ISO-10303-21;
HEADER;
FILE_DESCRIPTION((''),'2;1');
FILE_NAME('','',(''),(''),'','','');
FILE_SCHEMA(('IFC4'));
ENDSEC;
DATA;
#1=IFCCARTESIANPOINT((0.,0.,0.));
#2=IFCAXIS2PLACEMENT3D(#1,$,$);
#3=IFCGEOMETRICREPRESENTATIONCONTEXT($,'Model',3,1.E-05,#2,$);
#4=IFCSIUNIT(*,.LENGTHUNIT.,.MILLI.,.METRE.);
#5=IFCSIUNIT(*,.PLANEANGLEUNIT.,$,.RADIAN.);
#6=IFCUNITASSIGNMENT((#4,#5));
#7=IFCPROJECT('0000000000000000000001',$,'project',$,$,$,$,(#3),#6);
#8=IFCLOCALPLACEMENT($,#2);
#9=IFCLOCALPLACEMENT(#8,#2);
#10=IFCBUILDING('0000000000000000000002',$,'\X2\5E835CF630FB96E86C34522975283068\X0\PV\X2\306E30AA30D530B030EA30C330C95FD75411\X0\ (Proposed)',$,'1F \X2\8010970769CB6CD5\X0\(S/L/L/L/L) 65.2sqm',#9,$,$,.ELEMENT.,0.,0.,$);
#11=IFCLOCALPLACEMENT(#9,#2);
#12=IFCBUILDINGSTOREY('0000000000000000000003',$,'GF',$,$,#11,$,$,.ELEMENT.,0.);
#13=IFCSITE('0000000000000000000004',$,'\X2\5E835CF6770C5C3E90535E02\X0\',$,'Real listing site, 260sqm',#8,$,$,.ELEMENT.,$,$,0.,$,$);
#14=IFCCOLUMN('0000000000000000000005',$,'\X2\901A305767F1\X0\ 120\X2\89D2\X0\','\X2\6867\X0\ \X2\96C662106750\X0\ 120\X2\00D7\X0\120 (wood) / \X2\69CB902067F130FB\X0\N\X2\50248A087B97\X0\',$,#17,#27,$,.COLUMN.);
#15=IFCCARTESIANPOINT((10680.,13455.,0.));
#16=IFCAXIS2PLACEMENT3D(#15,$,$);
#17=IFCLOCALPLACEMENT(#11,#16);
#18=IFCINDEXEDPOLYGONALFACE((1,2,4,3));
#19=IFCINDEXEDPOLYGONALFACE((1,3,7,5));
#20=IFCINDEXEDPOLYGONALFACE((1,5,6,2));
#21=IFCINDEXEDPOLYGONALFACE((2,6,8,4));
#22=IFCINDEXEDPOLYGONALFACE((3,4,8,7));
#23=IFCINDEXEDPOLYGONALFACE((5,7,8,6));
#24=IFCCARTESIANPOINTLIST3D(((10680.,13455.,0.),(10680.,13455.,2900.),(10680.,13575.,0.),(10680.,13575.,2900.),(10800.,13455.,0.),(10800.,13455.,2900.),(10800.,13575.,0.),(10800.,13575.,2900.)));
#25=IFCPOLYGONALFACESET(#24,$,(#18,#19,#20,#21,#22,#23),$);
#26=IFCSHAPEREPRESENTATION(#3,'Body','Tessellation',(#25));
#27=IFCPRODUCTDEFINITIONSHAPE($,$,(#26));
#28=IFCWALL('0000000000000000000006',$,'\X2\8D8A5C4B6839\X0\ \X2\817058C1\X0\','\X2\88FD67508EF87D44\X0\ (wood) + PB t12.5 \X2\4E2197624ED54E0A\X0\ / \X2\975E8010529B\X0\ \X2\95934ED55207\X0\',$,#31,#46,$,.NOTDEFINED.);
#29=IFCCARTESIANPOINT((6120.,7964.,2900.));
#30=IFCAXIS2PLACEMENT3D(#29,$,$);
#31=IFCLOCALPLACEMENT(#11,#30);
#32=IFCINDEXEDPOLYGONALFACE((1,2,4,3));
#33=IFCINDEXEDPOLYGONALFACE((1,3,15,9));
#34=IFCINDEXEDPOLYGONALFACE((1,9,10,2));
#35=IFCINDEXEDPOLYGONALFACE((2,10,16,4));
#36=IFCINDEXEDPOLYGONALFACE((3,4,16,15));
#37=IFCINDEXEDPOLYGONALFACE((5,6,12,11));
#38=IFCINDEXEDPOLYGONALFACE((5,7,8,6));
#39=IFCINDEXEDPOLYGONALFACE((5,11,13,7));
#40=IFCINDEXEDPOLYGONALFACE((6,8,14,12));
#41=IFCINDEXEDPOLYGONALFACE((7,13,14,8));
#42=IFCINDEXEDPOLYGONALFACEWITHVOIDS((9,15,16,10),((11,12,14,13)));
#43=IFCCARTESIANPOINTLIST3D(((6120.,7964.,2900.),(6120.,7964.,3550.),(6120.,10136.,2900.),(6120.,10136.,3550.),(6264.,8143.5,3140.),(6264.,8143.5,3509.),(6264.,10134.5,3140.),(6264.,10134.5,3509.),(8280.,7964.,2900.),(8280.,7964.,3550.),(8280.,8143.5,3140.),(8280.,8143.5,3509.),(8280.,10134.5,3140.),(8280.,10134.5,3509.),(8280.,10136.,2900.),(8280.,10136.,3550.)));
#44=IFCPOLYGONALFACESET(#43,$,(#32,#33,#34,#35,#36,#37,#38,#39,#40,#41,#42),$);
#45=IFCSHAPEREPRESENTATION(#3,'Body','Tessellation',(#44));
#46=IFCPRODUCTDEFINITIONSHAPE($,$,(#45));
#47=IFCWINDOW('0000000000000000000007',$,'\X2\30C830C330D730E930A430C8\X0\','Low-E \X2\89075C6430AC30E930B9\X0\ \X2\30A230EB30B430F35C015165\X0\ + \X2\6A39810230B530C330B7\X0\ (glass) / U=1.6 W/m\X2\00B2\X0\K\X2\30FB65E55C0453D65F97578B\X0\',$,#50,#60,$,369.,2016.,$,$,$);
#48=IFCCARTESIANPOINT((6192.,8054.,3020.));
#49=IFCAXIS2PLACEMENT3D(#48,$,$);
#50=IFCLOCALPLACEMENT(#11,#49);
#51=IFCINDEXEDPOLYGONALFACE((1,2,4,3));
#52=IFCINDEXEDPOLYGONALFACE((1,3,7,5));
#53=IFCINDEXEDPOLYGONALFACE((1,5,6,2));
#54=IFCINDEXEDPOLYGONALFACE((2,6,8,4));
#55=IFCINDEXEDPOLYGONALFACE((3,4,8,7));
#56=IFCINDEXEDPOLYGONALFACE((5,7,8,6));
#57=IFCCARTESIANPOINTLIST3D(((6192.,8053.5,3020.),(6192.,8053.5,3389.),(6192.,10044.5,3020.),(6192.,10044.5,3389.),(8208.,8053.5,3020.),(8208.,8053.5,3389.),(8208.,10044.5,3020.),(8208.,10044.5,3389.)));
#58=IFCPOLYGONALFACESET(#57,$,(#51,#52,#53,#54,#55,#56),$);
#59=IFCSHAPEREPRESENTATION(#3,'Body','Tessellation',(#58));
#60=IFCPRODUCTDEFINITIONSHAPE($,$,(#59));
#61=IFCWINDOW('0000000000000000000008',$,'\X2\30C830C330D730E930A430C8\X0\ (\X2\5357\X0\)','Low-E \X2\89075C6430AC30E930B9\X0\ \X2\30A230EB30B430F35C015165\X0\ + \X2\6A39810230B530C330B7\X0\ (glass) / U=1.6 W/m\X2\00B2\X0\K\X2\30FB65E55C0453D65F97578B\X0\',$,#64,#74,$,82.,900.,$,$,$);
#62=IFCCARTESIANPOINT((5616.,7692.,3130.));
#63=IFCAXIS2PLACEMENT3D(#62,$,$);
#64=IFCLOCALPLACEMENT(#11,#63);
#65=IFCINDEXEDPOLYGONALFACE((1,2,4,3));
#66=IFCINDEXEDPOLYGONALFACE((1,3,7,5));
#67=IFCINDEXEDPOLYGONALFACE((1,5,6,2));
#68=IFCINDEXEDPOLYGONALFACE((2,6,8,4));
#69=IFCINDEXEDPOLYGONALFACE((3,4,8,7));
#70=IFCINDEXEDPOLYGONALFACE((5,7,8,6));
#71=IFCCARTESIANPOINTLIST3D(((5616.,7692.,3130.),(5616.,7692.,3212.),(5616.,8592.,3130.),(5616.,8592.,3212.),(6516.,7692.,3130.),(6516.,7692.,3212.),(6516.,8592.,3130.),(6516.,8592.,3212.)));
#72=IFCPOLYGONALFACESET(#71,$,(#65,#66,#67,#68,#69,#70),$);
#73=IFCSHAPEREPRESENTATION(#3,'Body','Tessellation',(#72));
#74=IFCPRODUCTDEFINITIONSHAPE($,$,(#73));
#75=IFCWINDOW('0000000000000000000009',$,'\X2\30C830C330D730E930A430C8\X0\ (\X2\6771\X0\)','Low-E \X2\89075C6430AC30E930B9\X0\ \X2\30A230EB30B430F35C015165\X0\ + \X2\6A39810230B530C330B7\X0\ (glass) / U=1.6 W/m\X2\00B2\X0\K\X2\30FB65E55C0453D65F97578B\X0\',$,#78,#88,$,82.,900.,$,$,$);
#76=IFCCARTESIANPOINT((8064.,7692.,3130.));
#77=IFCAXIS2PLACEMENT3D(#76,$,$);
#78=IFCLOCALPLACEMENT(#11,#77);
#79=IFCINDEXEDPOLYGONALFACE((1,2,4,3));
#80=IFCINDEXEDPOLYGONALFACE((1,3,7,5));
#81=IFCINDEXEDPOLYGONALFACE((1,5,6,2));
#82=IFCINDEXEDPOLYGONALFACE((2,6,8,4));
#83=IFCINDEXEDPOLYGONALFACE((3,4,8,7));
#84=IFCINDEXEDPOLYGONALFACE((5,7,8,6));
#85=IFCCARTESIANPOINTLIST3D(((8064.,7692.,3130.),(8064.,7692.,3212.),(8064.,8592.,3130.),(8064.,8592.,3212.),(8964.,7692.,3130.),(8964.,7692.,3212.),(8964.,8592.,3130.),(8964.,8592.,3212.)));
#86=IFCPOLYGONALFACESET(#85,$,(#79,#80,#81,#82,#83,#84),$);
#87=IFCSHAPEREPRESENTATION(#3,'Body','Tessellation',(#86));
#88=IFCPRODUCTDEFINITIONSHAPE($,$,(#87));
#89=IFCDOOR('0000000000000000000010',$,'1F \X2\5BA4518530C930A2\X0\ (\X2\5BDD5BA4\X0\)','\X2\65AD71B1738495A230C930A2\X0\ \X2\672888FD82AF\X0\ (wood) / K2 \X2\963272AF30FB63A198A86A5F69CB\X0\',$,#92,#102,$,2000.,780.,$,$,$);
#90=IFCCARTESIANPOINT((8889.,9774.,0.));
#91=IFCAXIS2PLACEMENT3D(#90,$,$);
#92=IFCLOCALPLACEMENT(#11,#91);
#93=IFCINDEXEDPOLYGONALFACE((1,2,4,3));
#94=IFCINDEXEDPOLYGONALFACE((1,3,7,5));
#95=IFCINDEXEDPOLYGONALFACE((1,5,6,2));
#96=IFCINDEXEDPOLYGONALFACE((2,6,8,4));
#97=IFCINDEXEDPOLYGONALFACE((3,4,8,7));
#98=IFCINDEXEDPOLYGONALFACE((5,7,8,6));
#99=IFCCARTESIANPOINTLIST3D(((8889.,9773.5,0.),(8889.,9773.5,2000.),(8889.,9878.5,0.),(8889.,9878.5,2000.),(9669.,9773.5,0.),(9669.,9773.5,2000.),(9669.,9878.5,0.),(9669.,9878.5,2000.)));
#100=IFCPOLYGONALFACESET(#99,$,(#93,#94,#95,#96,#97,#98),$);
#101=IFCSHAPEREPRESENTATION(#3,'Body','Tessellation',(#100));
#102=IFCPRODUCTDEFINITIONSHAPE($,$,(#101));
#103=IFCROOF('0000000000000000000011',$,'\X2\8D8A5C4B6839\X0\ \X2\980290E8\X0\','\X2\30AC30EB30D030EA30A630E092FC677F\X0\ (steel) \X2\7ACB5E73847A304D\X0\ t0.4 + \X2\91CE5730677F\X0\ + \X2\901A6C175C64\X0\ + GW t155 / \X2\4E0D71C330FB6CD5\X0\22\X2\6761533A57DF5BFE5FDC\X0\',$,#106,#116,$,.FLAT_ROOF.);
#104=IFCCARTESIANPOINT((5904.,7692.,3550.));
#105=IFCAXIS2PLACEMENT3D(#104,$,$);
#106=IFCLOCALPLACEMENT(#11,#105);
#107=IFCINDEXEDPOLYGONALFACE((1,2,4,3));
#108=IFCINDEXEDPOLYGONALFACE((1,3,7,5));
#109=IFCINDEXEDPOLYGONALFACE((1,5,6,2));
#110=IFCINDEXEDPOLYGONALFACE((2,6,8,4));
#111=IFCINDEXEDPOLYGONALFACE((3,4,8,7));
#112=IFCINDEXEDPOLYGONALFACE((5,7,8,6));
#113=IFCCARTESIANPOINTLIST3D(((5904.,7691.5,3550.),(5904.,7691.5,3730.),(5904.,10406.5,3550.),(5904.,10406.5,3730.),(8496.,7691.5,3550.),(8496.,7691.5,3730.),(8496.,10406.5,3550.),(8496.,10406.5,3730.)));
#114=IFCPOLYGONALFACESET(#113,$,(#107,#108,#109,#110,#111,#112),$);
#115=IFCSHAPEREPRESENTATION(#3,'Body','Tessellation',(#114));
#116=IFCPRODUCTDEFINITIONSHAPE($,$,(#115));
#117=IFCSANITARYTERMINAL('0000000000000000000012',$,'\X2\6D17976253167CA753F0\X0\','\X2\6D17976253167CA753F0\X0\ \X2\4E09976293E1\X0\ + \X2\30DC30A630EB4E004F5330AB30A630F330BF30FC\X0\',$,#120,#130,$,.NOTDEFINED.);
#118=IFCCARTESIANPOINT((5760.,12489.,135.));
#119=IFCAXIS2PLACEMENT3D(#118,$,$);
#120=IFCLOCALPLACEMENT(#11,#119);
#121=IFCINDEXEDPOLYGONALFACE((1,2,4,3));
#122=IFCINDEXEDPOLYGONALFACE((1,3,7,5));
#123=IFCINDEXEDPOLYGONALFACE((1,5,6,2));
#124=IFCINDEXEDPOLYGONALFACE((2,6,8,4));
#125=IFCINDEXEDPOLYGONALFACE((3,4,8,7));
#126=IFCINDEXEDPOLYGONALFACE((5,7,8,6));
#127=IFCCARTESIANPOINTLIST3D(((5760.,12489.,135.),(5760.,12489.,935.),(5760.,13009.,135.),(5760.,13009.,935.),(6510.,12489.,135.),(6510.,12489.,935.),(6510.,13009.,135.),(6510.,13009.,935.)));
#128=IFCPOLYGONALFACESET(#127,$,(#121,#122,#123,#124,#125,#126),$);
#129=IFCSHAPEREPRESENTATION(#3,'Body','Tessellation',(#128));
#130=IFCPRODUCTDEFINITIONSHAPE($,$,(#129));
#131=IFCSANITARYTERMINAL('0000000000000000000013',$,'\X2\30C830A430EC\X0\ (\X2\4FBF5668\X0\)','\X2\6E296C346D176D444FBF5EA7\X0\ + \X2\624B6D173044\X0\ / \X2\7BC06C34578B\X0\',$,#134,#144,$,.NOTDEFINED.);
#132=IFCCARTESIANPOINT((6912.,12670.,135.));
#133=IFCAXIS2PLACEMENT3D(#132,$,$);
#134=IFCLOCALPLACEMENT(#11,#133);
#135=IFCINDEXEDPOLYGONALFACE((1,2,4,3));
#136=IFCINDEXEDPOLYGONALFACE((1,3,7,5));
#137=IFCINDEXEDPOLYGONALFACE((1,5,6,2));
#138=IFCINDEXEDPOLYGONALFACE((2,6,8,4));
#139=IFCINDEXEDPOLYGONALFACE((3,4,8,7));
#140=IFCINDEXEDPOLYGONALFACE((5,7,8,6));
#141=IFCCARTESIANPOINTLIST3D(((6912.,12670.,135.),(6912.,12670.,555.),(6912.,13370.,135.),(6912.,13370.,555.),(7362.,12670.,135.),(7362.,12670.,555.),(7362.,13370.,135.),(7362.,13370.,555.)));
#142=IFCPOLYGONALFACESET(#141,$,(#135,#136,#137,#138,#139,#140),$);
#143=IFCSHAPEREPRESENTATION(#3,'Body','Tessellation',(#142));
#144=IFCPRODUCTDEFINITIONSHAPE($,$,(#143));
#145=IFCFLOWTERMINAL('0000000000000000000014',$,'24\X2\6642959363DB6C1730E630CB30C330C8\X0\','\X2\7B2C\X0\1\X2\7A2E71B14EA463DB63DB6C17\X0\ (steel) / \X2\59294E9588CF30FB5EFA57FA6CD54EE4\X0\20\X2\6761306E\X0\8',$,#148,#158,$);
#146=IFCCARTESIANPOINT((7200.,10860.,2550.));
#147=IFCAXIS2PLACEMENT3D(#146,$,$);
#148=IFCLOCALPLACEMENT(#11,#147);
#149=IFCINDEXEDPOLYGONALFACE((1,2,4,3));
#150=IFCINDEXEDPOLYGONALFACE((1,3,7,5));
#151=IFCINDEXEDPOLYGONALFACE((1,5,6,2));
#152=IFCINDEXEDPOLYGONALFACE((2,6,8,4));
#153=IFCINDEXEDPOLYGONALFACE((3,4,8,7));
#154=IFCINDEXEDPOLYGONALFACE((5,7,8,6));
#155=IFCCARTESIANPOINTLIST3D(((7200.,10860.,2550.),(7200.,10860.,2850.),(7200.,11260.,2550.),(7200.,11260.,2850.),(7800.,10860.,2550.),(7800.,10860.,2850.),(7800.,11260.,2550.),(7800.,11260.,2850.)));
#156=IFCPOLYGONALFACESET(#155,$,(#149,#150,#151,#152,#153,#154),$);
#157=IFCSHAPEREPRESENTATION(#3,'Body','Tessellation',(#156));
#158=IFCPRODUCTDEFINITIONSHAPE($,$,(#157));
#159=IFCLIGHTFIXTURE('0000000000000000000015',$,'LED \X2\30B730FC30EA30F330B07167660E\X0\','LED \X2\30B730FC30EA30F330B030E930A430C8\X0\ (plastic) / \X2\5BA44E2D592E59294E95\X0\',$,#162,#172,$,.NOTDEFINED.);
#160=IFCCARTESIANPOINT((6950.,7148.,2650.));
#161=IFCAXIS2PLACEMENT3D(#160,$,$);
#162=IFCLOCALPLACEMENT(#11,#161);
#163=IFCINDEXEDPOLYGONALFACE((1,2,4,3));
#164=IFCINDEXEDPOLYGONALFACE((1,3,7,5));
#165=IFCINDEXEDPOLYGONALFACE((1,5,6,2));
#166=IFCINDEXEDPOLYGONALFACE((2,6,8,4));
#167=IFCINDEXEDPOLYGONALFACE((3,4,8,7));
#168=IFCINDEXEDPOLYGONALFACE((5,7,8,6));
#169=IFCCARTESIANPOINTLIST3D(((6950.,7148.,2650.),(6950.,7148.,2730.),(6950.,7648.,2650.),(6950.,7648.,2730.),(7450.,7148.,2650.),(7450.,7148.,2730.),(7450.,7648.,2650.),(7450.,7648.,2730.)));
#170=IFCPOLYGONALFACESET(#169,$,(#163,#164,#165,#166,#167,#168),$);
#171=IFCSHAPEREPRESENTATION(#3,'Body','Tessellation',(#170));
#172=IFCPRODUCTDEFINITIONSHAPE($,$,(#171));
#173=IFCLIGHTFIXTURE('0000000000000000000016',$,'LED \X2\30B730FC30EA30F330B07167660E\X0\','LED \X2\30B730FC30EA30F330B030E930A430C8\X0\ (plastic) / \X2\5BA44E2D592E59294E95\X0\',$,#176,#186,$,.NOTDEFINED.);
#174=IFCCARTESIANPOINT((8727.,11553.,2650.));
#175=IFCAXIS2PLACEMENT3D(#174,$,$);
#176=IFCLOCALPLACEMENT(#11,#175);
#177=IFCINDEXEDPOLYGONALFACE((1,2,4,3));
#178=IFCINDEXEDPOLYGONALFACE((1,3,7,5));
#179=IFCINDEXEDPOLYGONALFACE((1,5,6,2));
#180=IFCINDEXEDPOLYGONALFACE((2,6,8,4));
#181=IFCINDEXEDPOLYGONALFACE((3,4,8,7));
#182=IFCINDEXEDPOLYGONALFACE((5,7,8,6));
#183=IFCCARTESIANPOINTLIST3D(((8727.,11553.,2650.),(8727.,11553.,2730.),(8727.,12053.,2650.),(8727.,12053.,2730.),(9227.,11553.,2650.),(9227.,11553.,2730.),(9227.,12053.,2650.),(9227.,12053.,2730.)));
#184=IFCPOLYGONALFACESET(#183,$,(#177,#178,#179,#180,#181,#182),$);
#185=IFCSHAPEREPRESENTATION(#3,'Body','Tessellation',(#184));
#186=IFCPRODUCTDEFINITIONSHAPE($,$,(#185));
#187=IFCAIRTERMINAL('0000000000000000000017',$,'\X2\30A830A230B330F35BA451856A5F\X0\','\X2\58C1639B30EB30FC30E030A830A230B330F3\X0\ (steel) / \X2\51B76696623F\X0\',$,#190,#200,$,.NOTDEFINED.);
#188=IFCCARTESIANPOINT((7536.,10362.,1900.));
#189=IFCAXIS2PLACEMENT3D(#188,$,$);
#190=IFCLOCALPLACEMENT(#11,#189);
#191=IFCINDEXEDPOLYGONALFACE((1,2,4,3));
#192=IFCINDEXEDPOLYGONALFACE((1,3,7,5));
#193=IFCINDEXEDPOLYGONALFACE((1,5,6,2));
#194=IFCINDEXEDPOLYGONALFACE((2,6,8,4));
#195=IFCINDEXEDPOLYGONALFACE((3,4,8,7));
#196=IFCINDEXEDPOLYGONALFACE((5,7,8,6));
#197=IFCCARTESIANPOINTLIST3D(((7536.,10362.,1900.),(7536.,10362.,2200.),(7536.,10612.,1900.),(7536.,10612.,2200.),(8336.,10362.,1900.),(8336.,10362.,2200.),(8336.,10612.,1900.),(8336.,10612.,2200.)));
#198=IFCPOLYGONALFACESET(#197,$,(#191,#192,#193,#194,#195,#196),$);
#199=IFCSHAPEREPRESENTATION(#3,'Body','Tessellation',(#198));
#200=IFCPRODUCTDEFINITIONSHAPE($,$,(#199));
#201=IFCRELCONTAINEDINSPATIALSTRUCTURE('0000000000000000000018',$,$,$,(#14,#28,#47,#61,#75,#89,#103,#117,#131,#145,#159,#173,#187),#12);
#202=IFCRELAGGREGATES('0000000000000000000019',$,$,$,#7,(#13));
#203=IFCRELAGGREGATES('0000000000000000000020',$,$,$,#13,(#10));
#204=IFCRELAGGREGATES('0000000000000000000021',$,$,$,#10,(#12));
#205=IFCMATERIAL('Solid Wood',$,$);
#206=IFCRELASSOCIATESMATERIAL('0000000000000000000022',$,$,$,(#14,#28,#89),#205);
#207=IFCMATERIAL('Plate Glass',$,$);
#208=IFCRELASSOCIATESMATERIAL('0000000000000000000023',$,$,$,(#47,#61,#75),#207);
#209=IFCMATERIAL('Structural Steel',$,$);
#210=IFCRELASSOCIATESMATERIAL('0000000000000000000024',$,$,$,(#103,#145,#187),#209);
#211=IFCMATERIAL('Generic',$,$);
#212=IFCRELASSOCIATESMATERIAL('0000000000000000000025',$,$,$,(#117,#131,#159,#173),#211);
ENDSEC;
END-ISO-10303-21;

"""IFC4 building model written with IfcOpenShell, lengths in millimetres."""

from ifc_helpers import new_model, si_unit, frame, frame_2d, origin, place, context, project, spatial, rectangle, extrude, material, element, fill, save


model = new_model("IFC4")

# Units and contexts
model_context = context("Model", 3, precision=1e-05, world=origin())
ifc_project = project(units=[si_unit("LENGTHUNIT", "METRE", prefix="MILLI"), si_unit("PLANEANGLEUNIT", "RADIAN")], contexts=[model_context])

# Site, building, storey
site_placement = place(None, origin())
site = spatial("IfcSite", under=ifc_project, at=site_placement, Name="広島県尾道市", ObjectType="Real listing site, 260sqm", CompositionType="ELEMENT", RefElevation=0.0)
building_placement = place(site_placement, origin())
building = spatial("IfcBuilding", under=site, at=building_placement, Name="広島・雨水利用とPVのオフグリッド志向 (Proposed)", ObjectType="1F 耐震構法(S/L/L/L/L) 65.2sqm", CompositionType="ELEMENT", ElevationOfRefHeight=0.0, ElevationOfTerrain=0.0)
storey_placement = place(building_placement, origin())
storey = spatial("IfcBuildingStorey", under=building, at=storey_placement, Name="GF", CompositionType="ELEMENT", Elevation=0.0)

# Column
ifc_material_1 = material(Name="Solid Wood")
column_1_placement = place(storey_placement, frame((10680.0, 13455.0, 0.0)))
element("IfcColumn", 1, at=column_1_placement, inside=storey, material=ifc_material_1, Name="通し柱 120角", Description="桧 集成材 120×120 (wood) / 構造柱・N値計算", PredefinedType="COLUMN", context=model_context, shape_type="SweptSolid", body=[
    extrude(rectangle(XDim=120.0, YDim=120.0, at=frame_2d((60.0, 60.0))), frame((10680.0, 13455.0, 0.0)), (0.0, 0.0, 1.0), 2900.0),
])

# Wall, openings, windows
wall_1_placement = place(storey_placement, frame((6120.0, 7964.0, 2900.0)))
wall_1 = element("IfcWall", 2, at=wall_1_placement, inside=storey, material=ifc_material_1, Name="越屋根 腰壁", Description="製材軸組 (wood) + PB t12.5 両面仕上 / 非耐力 間仕切", PredefinedType="NOTDEFINED", context=model_context, shape_type="SweptSolid", body=[
    extrude(rectangle(XDim=2160.0, YDim=2172.0, at=frame_2d((1080.0, 1086.0))), frame((6120.0, 7964.0, 2900.0)), (0.0, 0.0, 1.0), 650.0),
])
opening_1_placement = place(storey_placement, frame((6192.0, 8054.0, 3020.0)))
opening_1 = element("IfcOpeningElement", 3, at=opening_1_placement, cuts=wall_1, PredefinedType="NOTDEFINED", context=model_context, shape_type="SweptSolid", body=[
    extrude(rectangle(XDim=2016.0, YDim=1991.0, at=frame_2d((1008.0, 995.0))), frame((6192.0, 8054.0, 3020.0)), (0.0, 0.0, 1.0), 369.0),
])
opening_2_placement = place(storey_placement, frame((5616.0, 7692.0, 3130.0)))
opening_2 = element("IfcOpeningElement", 4, at=opening_2_placement, cuts=wall_1, PredefinedType="NOTDEFINED", context=model_context, shape_type="SweptSolid", body=[
    extrude(rectangle(XDim=900.0, YDim=900.0, at=frame_2d((450.0, 450.0))), frame((5616.0, 7692.0, 3130.0)), (0.0, 0.0, 1.0), 82.0),
])
opening_3_placement = place(storey_placement, frame((8064.0, 7692.0, 3130.0)))
opening_3 = element("IfcOpeningElement", 5, at=opening_3_placement, cuts=wall_1, PredefinedType="NOTDEFINED", context=model_context, shape_type="SweptSolid", body=[
    extrude(rectangle(XDim=900.0, YDim=900.0, at=frame_2d((450.0, 450.0))), frame((8064.0, 7692.0, 3130.0)), (0.0, 0.0, 1.0), 82.0),
])
ifc_material_2 = material(Name="Plate Glass")
window_1_placement = place(storey_placement, frame((6192.0, 8054.0, 3020.0)))
window_1 = element("IfcWindow", 6, at=window_1_placement, inside=storey, material=ifc_material_2, Name="トップライト", Description="Low-E 複層ガラス アルゴン封入 + 樹脂サッシ (glass) / U=1.6 W/m²K・日射取得型", OverallHeight=369.0, OverallWidth=2016.0, context=model_context, shape_type="SweptSolid", body=[
    extrude(rectangle(XDim=2016.0, YDim=1991.0, at=frame_2d((1008.0, 995.0))), frame((6192.0, 8054.0, 3020.0)), (0.0, 0.0, 1.0), 369.0),
])
fill(opening_1, window_1)
window_2_placement = place(storey_placement, frame((5616.0, 7692.0, 3130.0)))
window_2 = element("IfcWindow", 7, at=window_2_placement, inside=storey, material=ifc_material_2, Name="トップライト (南)", Description="Low-E 複層ガラス アルゴン封入 + 樹脂サッシ (glass) / U=1.6 W/m²K・日射取得型", OverallHeight=82.0, OverallWidth=900.0, context=model_context, shape_type="SweptSolid", body=[
    extrude(rectangle(XDim=900.0, YDim=900.0, at=frame_2d((450.0, 450.0))), frame((5616.0, 7692.0, 3130.0)), (0.0, 0.0, 1.0), 82.0),
])
fill(opening_2, window_2)
window_3_placement = place(storey_placement, frame((8064.0, 7692.0, 3130.0)))
window_3 = element("IfcWindow", 8, at=window_3_placement, inside=storey, material=ifc_material_2, Name="トップライト (東)", Description="Low-E 複層ガラス アルゴン封入 + 樹脂サッシ (glass) / U=1.6 W/m²K・日射取得型", OverallHeight=82.0, OverallWidth=900.0, context=model_context, shape_type="SweptSolid", body=[
    extrude(rectangle(XDim=900.0, YDim=900.0, at=frame_2d((450.0, 450.0))), frame((8064.0, 7692.0, 3130.0)), (0.0, 0.0, 1.0), 82.0),
])
fill(opening_3, window_3)

# Door
door_placement = place(storey_placement, frame((8889.0, 9774.0, 0.0)))
element("IfcDoor", 9, at=door_placement, inside=storey, material=ifc_material_1, Name="1F 室内ドア (寝室)", Description="断熱玄関ドア 木製芯 (wood) / K2 防犯・採風機構", OverallHeight=2000.0, OverallWidth=780.0, context=model_context, shape_type="SweptSolid", body=[
    extrude(rectangle(XDim=780.0, YDim=105.0, at=frame_2d((390.0, 52.0))), frame((8889.0, 9774.0, 0.0)), (0.0, 0.0, 1.0), 2000.0),
])

# Roof
ifc_material_3 = material(Name="Structural Steel")
roof_placement = place(storey_placement, frame((5904.0, 7692.0, 3550.0)))
element("IfcRoof", 10, at=roof_placement, inside=storey, material=ifc_material_3, Name="越屋根 頂部", Description="ガルバリウム鋼板 (steel) 立平葺き t0.4 + 野地板 + 通気層 + GW t155 / 不燃・法22条区域対応", PredefinedType="FLAT_ROOF", context=model_context, shape_type="SweptSolid", body=[
    extrude(rectangle(XDim=2592.0, YDim=2715.0, at=frame_2d((1296.0, 1357.0))), frame((5904.0, 7692.0, 3550.0)), (0.0, 0.0, 1.0), 180.0),
])

# Sanitary terminals
ifc_material_4 = material(Name="Generic")
sanitary_terminal_1_placement = place(storey_placement, frame((5760.0, 12489.0, 135.0)))
element("IfcSanitaryTerminal", 11, at=sanitary_terminal_1_placement, inside=storey, material=ifc_material_4, Name="洗面化粧台", Description="洗面化粧台 三面鏡 + ボウル一体カウンター", PredefinedType="NOTDEFINED", context=model_context, shape_type="SweptSolid", body=[
    extrude(rectangle(XDim=750.0, YDim=520.0, at=frame_2d((375.0, 260.0))), frame((5760.0, 12489.0, 135.0)), (0.0, 0.0, 1.0), 800.0),
])
sanitary_terminal_2_placement = place(storey_placement, frame((6912.0, 12670.0, 135.0)))
element("IfcSanitaryTerminal", 12, at=sanitary_terminal_2_placement, inside=storey, material=ifc_material_4, Name="トイレ (便器)", Description="温水洗浄便座 + 手洗い / 節水型", PredefinedType="NOTDEFINED", context=model_context, shape_type="SweptSolid", body=[
    extrude(rectangle(XDim=450.0, YDim=700.0, at=frame_2d((225.0, 350.0))), frame((6912.0, 12670.0, 135.0)), (0.0, 0.0, 1.0), 420.0),
])

# Flow terminal
flow_terminal_placement = place(storey_placement, frame((7200.0, 10860.0, 2550.0)))
element("IfcFlowTerminal", 13, at=flow_terminal_placement, inside=storey, material=ifc_material_3, Name="24時間換気ユニット", Description="第1種熱交換換気 (steel) / 天井裏・建基法令20条の8", context=model_context, shape_type="SweptSolid", body=[
    extrude(rectangle(XDim=600.0, YDim=400.0, at=frame_2d((300.0, 200.0))), frame((7200.0, 10860.0, 2550.0)), (0.0, 0.0, 1.0), 300.0),
])

# Light fixtures
light_fixture_1_placement = place(storey_placement, frame((6950.0, 7148.0, 2650.0)))
element("IfcLightFixture", 14, at=light_fixture_1_placement, inside=storey, material=ifc_material_4, Name="LED シーリング照明", Description="LED シーリングライト (plastic) / 室中央天井", PredefinedType="NOTDEFINED", context=model_context, shape_type="SweptSolid", body=[
    extrude(rectangle(XDim=500.0, YDim=500.0, at=frame_2d((250.0, 250.0))), frame((6950.0, 7148.0, 2650.0)), (0.0, 0.0, 1.0), 80.0),
])
light_fixture_2_placement = place(storey_placement, frame((8727.0, 11553.0, 2650.0)))
element("IfcLightFixture", 15, at=light_fixture_2_placement, inside=storey, material=ifc_material_4, Name="LED シーリング照明", Description="LED シーリングライト (plastic) / 室中央天井", PredefinedType="NOTDEFINED", context=model_context, shape_type="SweptSolid", body=[
    extrude(rectangle(XDim=500.0, YDim=500.0, at=frame_2d((250.0, 250.0))), frame((8727.0, 11553.0, 2650.0)), (0.0, 0.0, 1.0), 80.0),
])

# Air terminal
air_terminal_placement = place(storey_placement, frame((7536.0, 10362.0, 1900.0)))
element("IfcAirTerminal", 16, at=air_terminal_placement, inside=storey, material=ifc_material_3, Name="エアコン室内機", Description="壁掛ルームエアコン (steel) / 冷暖房", PredefinedType="NOTDEFINED", context=model_context, shape_type="SweptSolid", body=[
    extrude(rectangle(XDim=800.0, YDim=250.0, at=frame_2d((400.0, 125.0))), frame((7536.0, 10362.0, 1900.0)), (0.0, 0.0, 1.0), 300.0),
])

save(model, "model.ifc")
